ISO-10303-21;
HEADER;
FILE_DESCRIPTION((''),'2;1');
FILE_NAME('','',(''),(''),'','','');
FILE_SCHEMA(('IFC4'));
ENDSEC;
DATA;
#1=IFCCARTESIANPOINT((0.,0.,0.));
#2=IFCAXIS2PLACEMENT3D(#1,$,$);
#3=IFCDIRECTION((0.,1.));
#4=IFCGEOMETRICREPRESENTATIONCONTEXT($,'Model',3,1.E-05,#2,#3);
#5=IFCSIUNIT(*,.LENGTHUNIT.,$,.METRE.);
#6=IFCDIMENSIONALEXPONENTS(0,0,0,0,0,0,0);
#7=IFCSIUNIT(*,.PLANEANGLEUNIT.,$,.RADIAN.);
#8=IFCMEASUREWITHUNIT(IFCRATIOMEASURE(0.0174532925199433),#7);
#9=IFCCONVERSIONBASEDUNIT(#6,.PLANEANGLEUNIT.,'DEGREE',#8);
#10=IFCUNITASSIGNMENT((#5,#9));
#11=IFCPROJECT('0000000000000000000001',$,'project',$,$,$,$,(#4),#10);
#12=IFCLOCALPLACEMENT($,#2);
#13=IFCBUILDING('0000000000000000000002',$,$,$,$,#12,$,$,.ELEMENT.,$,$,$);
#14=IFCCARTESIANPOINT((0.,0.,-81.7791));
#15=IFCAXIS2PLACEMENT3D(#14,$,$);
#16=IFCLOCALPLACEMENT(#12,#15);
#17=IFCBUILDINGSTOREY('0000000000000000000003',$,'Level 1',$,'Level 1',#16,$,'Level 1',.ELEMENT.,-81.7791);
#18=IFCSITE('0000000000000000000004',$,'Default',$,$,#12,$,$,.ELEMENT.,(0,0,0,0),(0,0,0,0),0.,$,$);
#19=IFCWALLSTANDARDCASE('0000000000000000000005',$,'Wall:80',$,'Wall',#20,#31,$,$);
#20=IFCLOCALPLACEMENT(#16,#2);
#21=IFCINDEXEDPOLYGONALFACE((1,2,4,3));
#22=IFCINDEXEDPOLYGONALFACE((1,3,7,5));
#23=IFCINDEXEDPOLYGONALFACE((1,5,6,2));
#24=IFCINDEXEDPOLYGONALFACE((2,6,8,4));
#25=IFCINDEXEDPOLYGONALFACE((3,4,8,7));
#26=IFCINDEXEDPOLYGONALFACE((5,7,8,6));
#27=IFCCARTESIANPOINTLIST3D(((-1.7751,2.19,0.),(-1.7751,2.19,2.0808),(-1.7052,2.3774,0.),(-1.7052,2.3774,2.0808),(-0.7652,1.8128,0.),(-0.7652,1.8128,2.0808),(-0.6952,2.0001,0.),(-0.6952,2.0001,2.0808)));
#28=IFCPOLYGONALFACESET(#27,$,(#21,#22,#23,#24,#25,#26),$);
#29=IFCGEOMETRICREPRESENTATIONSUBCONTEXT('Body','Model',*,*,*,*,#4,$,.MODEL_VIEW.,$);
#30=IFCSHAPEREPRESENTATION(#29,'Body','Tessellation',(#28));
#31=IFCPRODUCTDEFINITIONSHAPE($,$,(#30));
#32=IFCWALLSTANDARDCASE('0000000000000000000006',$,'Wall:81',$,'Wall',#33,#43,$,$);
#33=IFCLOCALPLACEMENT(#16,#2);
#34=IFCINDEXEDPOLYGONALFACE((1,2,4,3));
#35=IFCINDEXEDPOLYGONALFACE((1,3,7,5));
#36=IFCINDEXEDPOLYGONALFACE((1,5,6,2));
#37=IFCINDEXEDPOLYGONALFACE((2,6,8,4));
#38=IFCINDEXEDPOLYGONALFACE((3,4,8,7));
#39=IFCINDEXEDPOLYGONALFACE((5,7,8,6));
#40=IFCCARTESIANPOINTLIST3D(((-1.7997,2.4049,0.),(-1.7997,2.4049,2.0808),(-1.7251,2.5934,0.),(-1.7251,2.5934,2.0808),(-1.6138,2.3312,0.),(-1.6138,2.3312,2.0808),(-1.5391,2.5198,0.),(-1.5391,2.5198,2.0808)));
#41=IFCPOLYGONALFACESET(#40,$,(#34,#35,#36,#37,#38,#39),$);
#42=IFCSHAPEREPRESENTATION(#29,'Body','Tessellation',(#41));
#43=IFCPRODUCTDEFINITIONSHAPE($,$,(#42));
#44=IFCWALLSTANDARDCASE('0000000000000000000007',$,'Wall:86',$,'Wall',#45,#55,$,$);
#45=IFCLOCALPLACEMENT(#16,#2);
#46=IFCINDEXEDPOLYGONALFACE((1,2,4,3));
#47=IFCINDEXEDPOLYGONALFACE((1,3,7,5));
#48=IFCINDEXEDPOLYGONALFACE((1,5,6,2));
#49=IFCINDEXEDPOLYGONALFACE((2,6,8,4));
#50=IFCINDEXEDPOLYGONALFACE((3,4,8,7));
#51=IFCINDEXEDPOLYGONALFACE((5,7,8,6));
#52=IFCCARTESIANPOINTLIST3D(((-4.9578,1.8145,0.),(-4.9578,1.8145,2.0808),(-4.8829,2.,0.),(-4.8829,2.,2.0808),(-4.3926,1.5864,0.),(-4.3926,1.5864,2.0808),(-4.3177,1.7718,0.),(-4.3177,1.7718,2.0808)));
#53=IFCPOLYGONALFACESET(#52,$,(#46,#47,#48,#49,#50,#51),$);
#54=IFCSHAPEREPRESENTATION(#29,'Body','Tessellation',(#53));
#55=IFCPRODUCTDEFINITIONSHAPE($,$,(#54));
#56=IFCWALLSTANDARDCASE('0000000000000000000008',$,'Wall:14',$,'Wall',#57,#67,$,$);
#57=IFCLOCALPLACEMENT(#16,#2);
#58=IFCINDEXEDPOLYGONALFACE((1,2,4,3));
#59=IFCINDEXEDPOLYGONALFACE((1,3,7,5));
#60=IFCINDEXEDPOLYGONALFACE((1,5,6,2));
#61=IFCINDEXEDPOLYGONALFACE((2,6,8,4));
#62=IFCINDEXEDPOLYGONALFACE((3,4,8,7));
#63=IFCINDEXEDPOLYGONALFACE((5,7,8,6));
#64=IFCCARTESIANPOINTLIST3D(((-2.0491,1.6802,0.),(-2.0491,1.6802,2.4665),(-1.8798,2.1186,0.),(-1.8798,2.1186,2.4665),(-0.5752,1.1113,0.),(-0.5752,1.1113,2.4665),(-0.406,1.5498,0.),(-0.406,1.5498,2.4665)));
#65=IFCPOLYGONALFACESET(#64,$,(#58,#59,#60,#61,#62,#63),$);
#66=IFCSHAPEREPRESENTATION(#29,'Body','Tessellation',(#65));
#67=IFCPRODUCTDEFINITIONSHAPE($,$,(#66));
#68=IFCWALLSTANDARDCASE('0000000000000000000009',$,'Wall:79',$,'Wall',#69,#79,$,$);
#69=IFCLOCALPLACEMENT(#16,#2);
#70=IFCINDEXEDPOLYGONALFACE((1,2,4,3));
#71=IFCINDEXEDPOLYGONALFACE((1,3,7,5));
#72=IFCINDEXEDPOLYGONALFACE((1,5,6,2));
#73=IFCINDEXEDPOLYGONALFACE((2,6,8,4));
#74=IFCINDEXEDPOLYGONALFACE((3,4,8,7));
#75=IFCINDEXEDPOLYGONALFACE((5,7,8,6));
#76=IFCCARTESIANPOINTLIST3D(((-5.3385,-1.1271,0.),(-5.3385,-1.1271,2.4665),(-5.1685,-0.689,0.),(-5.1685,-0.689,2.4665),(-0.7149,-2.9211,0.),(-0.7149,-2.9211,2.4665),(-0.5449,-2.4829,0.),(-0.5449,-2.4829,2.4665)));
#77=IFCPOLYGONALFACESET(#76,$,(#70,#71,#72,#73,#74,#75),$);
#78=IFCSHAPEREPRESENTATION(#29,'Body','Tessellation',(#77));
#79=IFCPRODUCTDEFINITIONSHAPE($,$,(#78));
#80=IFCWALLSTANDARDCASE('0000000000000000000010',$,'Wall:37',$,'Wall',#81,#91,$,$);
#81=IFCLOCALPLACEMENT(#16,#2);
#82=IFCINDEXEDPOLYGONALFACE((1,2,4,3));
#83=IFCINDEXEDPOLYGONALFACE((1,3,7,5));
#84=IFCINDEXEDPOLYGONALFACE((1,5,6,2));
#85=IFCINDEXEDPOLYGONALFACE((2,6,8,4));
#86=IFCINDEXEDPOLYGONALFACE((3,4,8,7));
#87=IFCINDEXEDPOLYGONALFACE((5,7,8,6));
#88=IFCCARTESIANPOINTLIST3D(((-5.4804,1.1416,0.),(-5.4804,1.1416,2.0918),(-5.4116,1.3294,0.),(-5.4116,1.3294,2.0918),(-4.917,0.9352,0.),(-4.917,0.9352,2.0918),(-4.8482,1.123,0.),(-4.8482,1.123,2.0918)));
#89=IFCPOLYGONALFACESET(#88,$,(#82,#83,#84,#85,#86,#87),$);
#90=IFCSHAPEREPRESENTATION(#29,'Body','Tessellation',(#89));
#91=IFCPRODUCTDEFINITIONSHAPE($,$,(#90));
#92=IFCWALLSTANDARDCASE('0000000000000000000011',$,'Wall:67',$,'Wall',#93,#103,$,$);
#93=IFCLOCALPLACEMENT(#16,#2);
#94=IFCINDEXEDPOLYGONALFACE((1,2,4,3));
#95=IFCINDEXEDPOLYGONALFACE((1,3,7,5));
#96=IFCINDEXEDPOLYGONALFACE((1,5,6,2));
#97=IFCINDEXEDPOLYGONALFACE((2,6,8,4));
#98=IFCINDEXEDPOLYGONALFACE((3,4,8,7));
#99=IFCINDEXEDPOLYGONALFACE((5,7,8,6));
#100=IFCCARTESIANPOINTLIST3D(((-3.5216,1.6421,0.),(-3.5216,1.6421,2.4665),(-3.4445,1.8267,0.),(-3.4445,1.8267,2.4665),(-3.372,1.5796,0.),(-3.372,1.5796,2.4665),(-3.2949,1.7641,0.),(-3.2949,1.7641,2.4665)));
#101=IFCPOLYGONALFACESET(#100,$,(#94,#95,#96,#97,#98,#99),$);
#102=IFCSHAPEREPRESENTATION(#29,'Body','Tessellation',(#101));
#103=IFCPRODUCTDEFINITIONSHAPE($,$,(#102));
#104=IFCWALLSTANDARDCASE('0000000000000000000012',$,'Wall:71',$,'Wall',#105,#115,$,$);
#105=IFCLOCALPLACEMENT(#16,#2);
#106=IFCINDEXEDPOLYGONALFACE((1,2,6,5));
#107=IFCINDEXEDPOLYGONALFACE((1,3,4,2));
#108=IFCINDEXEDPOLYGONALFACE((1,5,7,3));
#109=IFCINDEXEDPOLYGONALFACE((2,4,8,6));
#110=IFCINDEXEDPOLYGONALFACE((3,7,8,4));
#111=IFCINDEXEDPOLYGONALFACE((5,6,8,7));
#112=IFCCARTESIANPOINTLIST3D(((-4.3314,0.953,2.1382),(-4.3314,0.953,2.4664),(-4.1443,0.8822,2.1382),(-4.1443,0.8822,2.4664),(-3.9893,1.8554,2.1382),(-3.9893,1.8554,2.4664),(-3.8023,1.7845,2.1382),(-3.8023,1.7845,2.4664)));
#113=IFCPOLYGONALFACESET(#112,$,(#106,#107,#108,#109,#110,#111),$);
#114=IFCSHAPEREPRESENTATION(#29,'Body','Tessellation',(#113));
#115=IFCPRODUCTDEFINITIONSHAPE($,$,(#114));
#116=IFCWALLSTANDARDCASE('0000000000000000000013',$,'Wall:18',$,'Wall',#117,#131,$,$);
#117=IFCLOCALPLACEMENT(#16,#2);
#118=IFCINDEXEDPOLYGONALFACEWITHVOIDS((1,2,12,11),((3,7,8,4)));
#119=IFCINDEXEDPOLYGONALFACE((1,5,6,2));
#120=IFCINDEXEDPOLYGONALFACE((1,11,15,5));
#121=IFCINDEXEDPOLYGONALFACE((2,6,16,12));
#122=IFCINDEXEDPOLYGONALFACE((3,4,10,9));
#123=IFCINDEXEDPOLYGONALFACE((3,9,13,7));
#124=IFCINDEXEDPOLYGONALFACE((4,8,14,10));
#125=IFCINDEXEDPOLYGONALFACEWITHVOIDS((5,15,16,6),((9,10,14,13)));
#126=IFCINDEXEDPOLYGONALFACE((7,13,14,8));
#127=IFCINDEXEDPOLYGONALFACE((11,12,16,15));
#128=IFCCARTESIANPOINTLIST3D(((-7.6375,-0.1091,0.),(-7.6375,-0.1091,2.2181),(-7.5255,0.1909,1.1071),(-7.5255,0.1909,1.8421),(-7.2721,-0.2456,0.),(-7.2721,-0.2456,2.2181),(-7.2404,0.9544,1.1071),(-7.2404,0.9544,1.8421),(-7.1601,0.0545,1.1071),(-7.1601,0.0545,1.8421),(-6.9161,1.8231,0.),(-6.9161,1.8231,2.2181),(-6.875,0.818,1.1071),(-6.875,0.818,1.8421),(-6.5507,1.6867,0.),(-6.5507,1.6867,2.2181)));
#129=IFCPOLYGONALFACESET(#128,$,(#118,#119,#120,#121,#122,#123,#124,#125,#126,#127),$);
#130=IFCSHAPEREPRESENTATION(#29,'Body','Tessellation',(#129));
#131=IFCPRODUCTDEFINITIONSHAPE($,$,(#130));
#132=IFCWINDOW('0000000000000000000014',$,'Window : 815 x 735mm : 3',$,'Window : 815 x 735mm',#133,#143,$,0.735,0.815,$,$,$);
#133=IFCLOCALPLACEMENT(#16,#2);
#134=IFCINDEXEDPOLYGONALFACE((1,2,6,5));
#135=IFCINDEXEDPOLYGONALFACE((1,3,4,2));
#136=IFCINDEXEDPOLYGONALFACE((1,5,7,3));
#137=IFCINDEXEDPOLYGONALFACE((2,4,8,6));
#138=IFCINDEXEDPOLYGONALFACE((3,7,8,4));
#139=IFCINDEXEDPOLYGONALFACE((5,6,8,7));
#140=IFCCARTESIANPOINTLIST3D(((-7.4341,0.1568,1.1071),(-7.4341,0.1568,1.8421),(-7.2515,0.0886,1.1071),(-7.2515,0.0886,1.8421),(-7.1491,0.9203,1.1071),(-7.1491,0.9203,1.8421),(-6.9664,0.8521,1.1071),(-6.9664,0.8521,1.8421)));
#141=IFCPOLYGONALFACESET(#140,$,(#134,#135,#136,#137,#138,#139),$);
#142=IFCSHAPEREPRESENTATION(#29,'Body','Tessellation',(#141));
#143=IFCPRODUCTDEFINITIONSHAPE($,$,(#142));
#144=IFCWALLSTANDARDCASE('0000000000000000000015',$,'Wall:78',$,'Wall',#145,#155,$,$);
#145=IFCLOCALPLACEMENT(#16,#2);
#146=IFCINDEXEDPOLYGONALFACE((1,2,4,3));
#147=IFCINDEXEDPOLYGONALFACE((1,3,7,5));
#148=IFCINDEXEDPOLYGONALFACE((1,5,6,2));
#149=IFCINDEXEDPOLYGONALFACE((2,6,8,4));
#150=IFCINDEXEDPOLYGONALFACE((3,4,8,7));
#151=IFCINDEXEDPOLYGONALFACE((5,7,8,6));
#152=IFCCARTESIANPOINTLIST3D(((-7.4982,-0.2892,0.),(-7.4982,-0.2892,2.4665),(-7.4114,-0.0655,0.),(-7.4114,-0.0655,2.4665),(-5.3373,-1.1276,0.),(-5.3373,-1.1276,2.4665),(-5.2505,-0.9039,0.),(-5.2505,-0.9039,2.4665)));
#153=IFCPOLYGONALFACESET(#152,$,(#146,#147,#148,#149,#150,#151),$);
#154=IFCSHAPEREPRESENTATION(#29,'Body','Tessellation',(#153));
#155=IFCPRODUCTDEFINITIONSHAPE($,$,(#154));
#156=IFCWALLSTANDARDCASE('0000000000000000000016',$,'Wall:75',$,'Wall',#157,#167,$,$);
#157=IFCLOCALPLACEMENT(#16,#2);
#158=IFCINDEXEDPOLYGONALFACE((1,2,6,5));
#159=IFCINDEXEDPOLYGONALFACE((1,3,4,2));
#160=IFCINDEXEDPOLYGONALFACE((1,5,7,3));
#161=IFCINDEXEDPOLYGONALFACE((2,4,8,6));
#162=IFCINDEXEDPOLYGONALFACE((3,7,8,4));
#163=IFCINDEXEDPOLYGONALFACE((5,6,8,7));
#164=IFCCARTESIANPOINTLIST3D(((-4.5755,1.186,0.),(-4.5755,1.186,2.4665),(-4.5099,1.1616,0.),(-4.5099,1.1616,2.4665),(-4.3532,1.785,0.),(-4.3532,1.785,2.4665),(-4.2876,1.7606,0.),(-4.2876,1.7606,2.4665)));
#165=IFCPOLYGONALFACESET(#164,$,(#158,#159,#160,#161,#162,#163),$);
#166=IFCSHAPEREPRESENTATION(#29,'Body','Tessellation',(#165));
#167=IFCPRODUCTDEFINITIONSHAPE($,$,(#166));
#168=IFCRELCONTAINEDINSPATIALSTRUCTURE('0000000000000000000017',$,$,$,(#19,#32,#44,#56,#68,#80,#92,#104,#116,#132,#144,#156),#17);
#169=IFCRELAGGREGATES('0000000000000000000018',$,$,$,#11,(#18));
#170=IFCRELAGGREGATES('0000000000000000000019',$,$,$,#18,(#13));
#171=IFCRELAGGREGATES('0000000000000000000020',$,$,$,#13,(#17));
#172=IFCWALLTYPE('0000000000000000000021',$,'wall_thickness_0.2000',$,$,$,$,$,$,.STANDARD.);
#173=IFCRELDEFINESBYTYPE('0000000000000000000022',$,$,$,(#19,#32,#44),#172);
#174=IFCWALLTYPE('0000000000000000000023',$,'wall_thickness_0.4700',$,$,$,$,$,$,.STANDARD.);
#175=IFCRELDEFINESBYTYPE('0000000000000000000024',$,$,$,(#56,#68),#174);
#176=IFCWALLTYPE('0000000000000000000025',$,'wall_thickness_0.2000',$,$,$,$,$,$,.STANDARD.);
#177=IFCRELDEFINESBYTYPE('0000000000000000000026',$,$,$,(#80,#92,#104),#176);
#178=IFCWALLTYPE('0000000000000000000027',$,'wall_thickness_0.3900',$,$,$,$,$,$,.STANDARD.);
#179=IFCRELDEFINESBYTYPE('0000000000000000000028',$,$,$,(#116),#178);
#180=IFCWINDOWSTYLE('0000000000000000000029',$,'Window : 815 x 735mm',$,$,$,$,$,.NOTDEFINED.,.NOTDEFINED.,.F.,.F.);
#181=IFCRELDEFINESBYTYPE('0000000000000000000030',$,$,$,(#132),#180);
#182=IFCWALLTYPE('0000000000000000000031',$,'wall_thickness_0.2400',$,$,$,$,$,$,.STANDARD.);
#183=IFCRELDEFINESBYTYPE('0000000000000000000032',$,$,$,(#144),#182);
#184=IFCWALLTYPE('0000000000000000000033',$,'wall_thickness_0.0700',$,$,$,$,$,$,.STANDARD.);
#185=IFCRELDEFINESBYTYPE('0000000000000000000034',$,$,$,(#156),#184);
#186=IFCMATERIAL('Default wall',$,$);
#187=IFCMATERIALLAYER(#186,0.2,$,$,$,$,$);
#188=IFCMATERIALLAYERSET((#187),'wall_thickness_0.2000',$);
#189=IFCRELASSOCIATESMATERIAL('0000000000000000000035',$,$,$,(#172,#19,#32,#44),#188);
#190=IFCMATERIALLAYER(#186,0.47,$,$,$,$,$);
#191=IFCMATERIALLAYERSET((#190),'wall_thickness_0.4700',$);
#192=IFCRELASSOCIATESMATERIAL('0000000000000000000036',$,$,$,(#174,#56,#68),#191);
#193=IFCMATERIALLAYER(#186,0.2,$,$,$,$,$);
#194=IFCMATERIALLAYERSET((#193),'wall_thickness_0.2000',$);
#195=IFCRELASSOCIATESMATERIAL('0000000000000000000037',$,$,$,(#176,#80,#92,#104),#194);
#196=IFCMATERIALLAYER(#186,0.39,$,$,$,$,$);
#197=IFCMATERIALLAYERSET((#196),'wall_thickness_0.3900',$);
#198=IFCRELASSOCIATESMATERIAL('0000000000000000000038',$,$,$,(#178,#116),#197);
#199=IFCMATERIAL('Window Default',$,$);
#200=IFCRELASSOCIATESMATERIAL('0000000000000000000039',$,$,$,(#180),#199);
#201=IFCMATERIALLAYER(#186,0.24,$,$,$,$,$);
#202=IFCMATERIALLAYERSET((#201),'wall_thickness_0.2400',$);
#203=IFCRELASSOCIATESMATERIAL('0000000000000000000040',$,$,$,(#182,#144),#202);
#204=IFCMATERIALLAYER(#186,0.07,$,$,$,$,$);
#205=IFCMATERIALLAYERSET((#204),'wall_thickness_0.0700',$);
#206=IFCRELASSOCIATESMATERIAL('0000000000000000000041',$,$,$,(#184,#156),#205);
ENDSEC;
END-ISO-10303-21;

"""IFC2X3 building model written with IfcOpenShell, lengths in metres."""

from ifc_helpers import new_model, entity, si_unit, converted_unit, direction, frame, frame_2d, origin, origin_2d_with_axis, place, context, subcontext, project, spatial, polyline, rectangle, outline, extrude, source, transform, mapped, material, layer, layer_set, layer_usage, type_object, type_shapes, element, fill, save


model = new_model("IFC2X3")

# Units and contexts
model_context = context("Model", 3, precision=1e-05, world=origin(), true_north=direction((0.0, 1.0)))
body_context = subcontext(model_context, "Body", "Model", "MODEL_VIEW")
ifc_project = project(units=[si_unit("LENGTHUNIT", "METRE"), converted_unit("PLANEANGLEUNIT", "DEGREE", entity("IfcRatioMeasure", 0.0174532925199433), si_unit("PLANEANGLEUNIT", "RADIAN"), dimensions=[0, 0, 0, 0, 0, 0, 0])], contexts=[model_context])

# Site, building, storey
placement_1 = place(None, origin())
site = spatial("IfcSite", under=ifc_project, at=placement_1, Name="Default", CompositionType="ELEMENT", RefLatitude=(0, 0, 0, 0), RefLongitude=(0, 0, 0, 0), RefElevation=0.0)
building = spatial("IfcBuilding", under=site, at=placement_1, CompositionType="ELEMENT")
storey_placement = place(placement_1, frame((0.0, 0.0, -81.7791)))
storey = spatial("IfcBuildingStorey", under=building, at=storey_placement, Name="Level 1", ObjectType="Level 1", LongName="Level 1", CompositionType="ELEMENT", Elevation=-81.7791)

# Shared definitions
ifc_material_1 = material(Name="Default wall")
ifc_layer_1 = layer(ifc_material_1, 0.2)
ifc_layer_set_1 = layer_set([ifc_layer_1], Name="wall_thickness_0.2000")
ifc_layer_usage_1 = layer_usage(ifc_layer_set_1, "AXIS2", "POSITIVE", -0.1)
wall_type_1 = type_object("IfcWallType", Name="wall_thickness_0.2000", PredefinedType="STANDARD", material=ifc_layer_set_1)

# Shared definitions
ifc_material_2 = material(Name="Window Default")

# Walls
wall_1_placement = place(storey_placement, frame((-1.7402, 2.2837, 0.0), z_axis=(0.0, 0.0, 1.0), x_axis=(0.936778, -0.349923, 0.0)))
element("IfcWallStandardCase", 1, at=wall_1_placement, inside=storey, type_object=wall_type_1, material=ifc_layer_usage_1, Name="Wall:80", ObjectType="Wall", context=body_context, shape_type="SweptSolid", body=[
    extrude(outline(polyline([(1.0781, -0.1), (1.0781, 0.1), (0.0, 0.1), (0.0, -0.1), (1.0781, -0.1)])), origin(), (0.0, 0.0, 1.0), 2.0808),
])
wall_2_placement = place(storey_placement, frame((-1.6321, 2.5566, 0.0), z_axis=(0.0, 0.0, 1.0), x_axis=(-0.368127, -0.929775, 0.0)))
element("IfcWallStandardCase", 2, at=wall_2_placement, inside=storey, type_object=wall_type_1, material=ifc_layer_usage_1, Name="Wall:81", ObjectType="Wall", context=body_context, shape_type="SweptSolid", body=[
    extrude(outline(polyline([(0.2028, -0.1), (0.2028, 0.1), (0.0, 0.1), (0.0, -0.1), (0.2028, -0.1)])), origin(), (0.0, 0.0, 1.0), 2.0808),
])
wall_3_placement = place(storey_placement, frame((-4.9204, 1.9073, 0.0), z_axis=(0.0, 0.0, 1.0), x_axis=(0.927278, -0.374373, 0.0)))
element("IfcWallStandardCase", 3, at=wall_3_placement, inside=storey, type_object=wall_type_1, material=ifc_layer_usage_1, Name="Wall:86", ObjectType="Wall", context=body_context, shape_type="SweptSolid", body=[
    extrude(outline(polyline([(0.6095, -0.1), (0.6095, 0.1), (0.0, 0.1), (0.0, -0.1), (0.6095, -0.1)])), origin(), (0.0, 0.0, 1.0), 2.0808),
])
ifc_layer_2 = layer(ifc_material_1, 0.47)
ifc_layer_set_2 = layer_set([ifc_layer_2], Name="wall_thickness_0.4700")
ifc_layer_usage_2 = layer_usage(ifc_layer_set_2, "AXIS2", "POSITIVE", -0.235)
wall_type_2 = type_object("IfcWallType", Name="wall_thickness_0.4700", PredefinedType="STANDARD", material=ifc_layer_set_2)
wall_4_placement = place(storey_placement, frame((-1.9645, 1.8994, 0.0), z_axis=(0.0, 0.0, 1.0), x_axis=(0.93292, -0.360083, 0.0)))
element("IfcWallStandardCase", 4, at=wall_4_placement, inside=storey, type_object=wall_type_2, material=ifc_layer_usage_2, Name="Wall:14", ObjectType="Wall", context=body_context, shape_type="SweptSolid", body=[
    extrude(outline(polyline([(1.5798, -0.235), (1.5798, 0.235), (0.0, 0.235), (0.0, -0.235), (1.5798, -0.235)])), origin(), (0.0, 0.0, 1.0), 2.4665),
])
wall_5_placement = place(storey_placement, frame((-5.2535, -0.9081, 0.0), z_axis=(0.0, 0.0, 1.0), x_axis=(0.932288, -0.361716, 0.0)))
element("IfcWallStandardCase", 5, at=wall_5_placement, inside=storey, type_object=wall_type_2, material=ifc_layer_usage_2, Name="Wall:79", ObjectType="Wall", context=body_context, shape_type="SweptSolid", body=[
    extrude(outline(polyline([(4.9595, -0.235), (4.9595, 0.235), (0.0, 0.235), (0.0, -0.235), (4.9595, -0.235)])), origin(), (0.0, 0.0, 1.0), 2.4665),
])
ifc_layer_3 = layer(ifc_material_1, 0.2)
ifc_layer_set_3 = layer_set([ifc_layer_3], Name="wall_thickness_0.2000")
ifc_layer_usage_3 = layer_usage(ifc_layer_set_3, "AXIS2", "POSITIVE", -0.1)
wall_type_3 = type_object("IfcWallType", Name="wall_thickness_0.2000", PredefinedType="STANDARD", material=ifc_layer_set_3)
wall_6_placement = place(storey_placement, frame((-5.446, 1.2355, 0.0), z_axis=(0.0, 0.0, 1.0), x_axis=(0.938989, -0.343946, 0.0)))
element("IfcWallStandardCase", 6, at=wall_6_placement, inside=storey, type_object=wall_type_3, material=ifc_layer_usage_3, Name="Wall:37", ObjectType="Wall", context=body_context, shape_type="SweptSolid", body=[
    extrude(outline(polyline([(0.6, -0.1), (0.6, 0.1), (0.0, 0.1), (0.0, -0.1), (0.6, -0.1)])), origin(), (0.0, 0.0, 1.0), 2.0918),
])
wall_7_placement = place(storey_placement, frame((-3.4831, 1.7344, 0.0), z_axis=(0.0, 0.0, 1.0), x_axis=(0.922715, -0.385483, 0.0)))
element("IfcWallStandardCase", 7, at=wall_7_placement, inside=storey, type_object=wall_type_3, material=ifc_layer_usage_3, Name="Wall:67", ObjectType="Wall", context=body_context, shape_type="SweptSolid", body=[
    extrude(outline(polyline([(0.1621, -0.1), (0.1621, 0.1), (0.0, 0.1), (0.0, -0.1), (0.1621, -0.1)])), origin(), (0.0, 0.0, 1.0), 2.4665),
])
placement_2 = place(placement_1, frame((0.0, 0.0, -79.6409)))
wall_8_placement = place(placement_2, frame((-3.8958, 1.82, 0.0), z_axis=(0.0, 0.0, 1.0), x_axis=(-0.354428, -0.935083, 0.0)))
element("IfcWallStandardCase", 8, at=wall_8_placement, inside=storey, type_object=wall_type_3, material=ifc_layer_usage_3, Name="Wall:71", ObjectType="Wall", context=body_context, shape_type="SweptSolid", body=[
    extrude(outline(polyline([(0.965, -0.1), (0.965, 0.1), (0.0, 0.1), (0.0, -0.1), (0.965, -0.1)])), origin(), (0.0, 0.0, 1.0), 0.3282),
])

# Wall, opening, window
ifc_layer_4 = layer(ifc_material_1, 0.39)
ifc_layer_set_4 = layer_set([ifc_layer_4], Name="wall_thickness_0.3900")
ifc_layer_usage_4 = layer_usage(ifc_layer_set_4, "AXIS2", "POSITIVE", -0.195)
wall_type_4 = type_object("IfcWallType", Name="wall_thickness_0.3900", PredefinedType="STANDARD", material=ifc_layer_set_4)
wall_9_placement = place(storey_placement, frame((-6.7334, 1.7549, 0.0), z_axis=(0.0, 0.0, 1.0), x_axis=(-0.349788, -0.936829, 0.0)))
wall_9 = element("IfcWallStandardCase", 9, at=wall_9_placement, inside=storey, type_object=wall_type_4, material=ifc_layer_usage_4, Name="Wall:18", ObjectType="Wall", context=body_context, shape_type="SweptSolid", body=[
    extrude(outline(polyline([(2.0625, -0.195), (2.0625, 0.195), (0.0, 0.195), (0.0, -0.195), (2.0625, -0.195)])), origin(), (0.0, 0.0, 1.0), 2.2181),
])
opening_1_placement = place(wall_9_placement, frame((0.9273, -0.195, 1.1071)))
opening_1 = element("IfcOpeningElement", 10, at=opening_1_placement, cuts=wall_9, ObjectType="Opening", context=body_context, shape_type="SweptSolid", body=[
    extrude(rectangle(XDim=0.815, YDim=0.735, at=frame_2d((0.3675, 0.4075), x_axis=(0.0, 1.0))), frame((0.0, 0.0, 0.0), z_axis=(0.0, 1.0, 0.0), x_axis=(0.0, 0.0, 1.0)), (0.0, 0.0, 1.0), 0.39),
])
window_style_1 = type_object("IfcWindowStyle", Name="Window : 815 x 735mm", ConstructionType="NOTDEFINED", OperationType="NOTDEFINED", ParameterTakesPrecedence=False, Sizeable=False, material=ifc_material_2)
shared_shape_1 = source(origin(), body_context, "Body", "SweptSolid", [
    extrude(rectangle(XDim=0.195, YDim=0.815, at=origin_2d_with_axis()), frame((0.4075, 0.195, 0.0), z_axis=(0.0, 0.0, 1.0), x_axis=(0.0, 1.0, 0.0)), (0.0, 0.0, 1.0), 0.735),
])
type_shapes(window_style_1, [shared_shape_1])
window_1_placement = place(opening_1_placement, origin())
window_1 = element("IfcWindow", 11, at=window_1_placement, inside=storey, type_object=window_style_1, Name="Window : 815 x 735mm : 3", ObjectType="Window : 815 x 735mm", OverallHeight=0.735, OverallWidth=0.815, context=body_context, shape_type="MappedRepresentation", body=[
    mapped(shared_shape_1, transform((0.0, 0.0, 0.0), scale=1.0)),
])
fill(opening_1, window_1)

# Walls
ifc_layer_5 = layer(ifc_material_1, 0.24)
ifc_layer_set_5 = layer_set([ifc_layer_5], Name="wall_thickness_0.2400")
ifc_layer_usage_5 = layer_usage(ifc_layer_set_5, "AXIS2", "POSITIVE", -0.12)
wall_type_5 = type_object("IfcWallType", Name="wall_thickness_0.2400", PredefinedType="STANDARD", material=ifc_layer_set_5)
wall_10_placement = place(storey_placement, frame((-7.4548, -0.1773, 0.0), z_axis=(0.0, 0.0, 1.0), x_axis=(0.932288, -0.361716, 0.0)))
element("IfcWallStandardCase", 12, at=wall_10_placement, inside=storey, type_object=wall_type_5, material=ifc_layer_usage_5, Name="Wall:78", ObjectType="Wall", context=body_context, shape_type="SweptSolid", body=[
    extrude(outline(polyline([(2.3178, -0.12), (2.3178, 0.12), (0.0, 0.12), (0.0, -0.12), (2.3178, -0.12)])), origin(), (0.0, 0.0, 1.0), 2.4665),
])
ifc_layer_6 = layer(ifc_material_1, 0.07)
ifc_layer_set_6 = layer_set([ifc_layer_6], Name="wall_thickness_0.0700")
ifc_layer_usage_6 = layer_usage(ifc_layer_set_6, "AXIS2", "POSITIVE", -0.035)
wall_type_6 = type_object("IfcWallType", Name="wall_thickness_0.0700", PredefinedType="STANDARD", material=ifc_layer_set_6)
wall_11_placement = place(storey_placement, frame((-4.3204, 1.7728, 0.0), z_axis=(0.0, 0.0, 1.0), x_axis=(-0.347981, -0.937502, 0.0)))
element("IfcWallStandardCase", 13, at=wall_11_placement, inside=storey, type_object=wall_type_6, material=ifc_layer_usage_6, Name="Wall:75", ObjectType="Wall", context=body_context, shape_type="SweptSolid", body=[
    extrude(outline(polyline([(0.6389, -0.035), (0.6389, 0.035), (0.0, 0.035), (0.0, -0.035), (0.6389, -0.035)])), origin(), (0.0, 0.0, 1.0), 2.4665),
])

save(model, "model.ifc")
